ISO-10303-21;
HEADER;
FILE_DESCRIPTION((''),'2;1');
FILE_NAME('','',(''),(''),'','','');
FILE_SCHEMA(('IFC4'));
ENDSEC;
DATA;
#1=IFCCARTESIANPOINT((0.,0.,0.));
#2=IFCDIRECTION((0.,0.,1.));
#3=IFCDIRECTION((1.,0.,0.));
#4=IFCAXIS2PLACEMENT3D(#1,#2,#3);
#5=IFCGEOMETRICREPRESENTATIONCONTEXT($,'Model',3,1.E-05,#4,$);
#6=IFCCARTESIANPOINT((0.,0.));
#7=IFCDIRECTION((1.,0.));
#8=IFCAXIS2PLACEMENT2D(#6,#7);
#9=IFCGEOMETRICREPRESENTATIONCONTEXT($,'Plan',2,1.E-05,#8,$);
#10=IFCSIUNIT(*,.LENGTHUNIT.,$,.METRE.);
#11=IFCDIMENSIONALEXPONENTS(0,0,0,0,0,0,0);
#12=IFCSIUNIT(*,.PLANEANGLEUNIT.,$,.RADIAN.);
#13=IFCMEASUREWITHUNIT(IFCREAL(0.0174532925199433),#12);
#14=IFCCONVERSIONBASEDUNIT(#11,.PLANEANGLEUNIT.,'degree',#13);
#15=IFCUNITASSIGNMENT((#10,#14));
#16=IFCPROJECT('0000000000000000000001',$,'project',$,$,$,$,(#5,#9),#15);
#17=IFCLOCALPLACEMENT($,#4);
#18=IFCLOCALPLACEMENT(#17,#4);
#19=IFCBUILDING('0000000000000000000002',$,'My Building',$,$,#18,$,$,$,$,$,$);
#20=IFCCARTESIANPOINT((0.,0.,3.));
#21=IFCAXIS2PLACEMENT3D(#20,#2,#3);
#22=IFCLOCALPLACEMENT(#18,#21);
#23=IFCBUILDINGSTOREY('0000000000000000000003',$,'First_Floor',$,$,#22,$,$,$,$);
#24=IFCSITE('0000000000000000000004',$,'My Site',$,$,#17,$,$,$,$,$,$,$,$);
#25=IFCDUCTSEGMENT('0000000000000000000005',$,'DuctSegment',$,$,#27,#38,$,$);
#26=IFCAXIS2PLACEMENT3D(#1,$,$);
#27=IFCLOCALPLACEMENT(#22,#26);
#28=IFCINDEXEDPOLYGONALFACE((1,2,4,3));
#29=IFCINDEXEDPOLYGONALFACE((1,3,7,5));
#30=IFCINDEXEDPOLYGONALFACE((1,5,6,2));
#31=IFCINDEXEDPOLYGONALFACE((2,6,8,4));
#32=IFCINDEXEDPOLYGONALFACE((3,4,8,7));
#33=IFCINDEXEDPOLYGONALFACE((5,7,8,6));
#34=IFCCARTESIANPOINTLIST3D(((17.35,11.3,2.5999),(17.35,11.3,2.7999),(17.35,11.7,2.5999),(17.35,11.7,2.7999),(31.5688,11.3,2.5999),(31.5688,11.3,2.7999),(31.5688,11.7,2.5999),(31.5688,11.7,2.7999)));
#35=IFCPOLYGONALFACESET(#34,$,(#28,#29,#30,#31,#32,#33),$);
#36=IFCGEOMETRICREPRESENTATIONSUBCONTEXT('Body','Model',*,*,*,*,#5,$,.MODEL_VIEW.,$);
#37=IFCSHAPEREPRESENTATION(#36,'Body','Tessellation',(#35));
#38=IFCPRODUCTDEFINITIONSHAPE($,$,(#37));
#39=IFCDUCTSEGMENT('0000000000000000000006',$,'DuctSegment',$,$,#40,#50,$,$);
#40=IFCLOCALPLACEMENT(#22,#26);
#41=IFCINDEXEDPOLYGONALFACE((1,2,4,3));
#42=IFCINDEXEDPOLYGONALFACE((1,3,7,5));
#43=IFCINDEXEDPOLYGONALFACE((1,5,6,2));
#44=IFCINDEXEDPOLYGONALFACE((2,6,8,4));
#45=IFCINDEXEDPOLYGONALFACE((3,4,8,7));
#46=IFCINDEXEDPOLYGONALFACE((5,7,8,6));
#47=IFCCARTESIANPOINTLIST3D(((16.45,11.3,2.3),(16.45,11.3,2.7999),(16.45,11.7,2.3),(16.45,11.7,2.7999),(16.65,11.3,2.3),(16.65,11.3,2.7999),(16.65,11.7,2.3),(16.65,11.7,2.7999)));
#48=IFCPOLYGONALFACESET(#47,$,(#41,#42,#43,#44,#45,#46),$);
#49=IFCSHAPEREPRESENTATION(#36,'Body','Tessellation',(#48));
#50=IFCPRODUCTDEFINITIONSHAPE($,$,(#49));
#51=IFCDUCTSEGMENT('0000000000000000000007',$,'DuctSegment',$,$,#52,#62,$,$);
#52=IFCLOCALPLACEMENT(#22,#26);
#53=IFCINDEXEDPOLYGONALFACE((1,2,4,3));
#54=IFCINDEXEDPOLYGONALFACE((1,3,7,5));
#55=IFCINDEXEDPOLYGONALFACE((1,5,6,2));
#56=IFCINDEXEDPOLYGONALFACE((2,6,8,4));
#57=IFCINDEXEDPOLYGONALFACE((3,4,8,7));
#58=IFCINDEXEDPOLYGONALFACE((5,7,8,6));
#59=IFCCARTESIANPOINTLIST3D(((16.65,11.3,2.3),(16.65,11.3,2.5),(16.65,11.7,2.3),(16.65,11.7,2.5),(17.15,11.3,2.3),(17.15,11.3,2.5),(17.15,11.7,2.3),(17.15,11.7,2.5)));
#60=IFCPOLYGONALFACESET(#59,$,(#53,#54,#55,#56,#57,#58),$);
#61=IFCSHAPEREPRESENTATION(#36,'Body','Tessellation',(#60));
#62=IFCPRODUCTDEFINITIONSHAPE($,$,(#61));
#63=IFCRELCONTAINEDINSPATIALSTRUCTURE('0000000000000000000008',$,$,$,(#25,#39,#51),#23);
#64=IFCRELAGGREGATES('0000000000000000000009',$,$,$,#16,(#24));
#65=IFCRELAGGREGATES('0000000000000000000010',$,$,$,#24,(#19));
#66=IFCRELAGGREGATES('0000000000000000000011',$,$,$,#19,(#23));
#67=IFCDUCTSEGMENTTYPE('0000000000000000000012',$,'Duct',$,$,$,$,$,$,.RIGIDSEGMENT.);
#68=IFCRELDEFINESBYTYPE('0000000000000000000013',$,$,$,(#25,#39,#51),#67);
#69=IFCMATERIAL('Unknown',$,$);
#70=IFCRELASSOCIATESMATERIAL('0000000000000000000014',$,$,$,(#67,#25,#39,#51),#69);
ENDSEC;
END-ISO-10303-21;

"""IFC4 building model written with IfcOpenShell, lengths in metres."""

from ifc_helpers import new_model, entity, si_unit, converted_unit, frame, origin_with_axes, origin_2d_with_axis, place, context, subcontext, project, spatial, rectangle, extrude, material, material_profile, profile_set, profile_usage, type_object, element, save


model = new_model("IFC4")

# Units and contexts
model_context = context("Model", 3, precision=1e-05, world=origin_with_axes())
plan_context = context("Plan", 2, precision=1e-05, world=origin_2d_with_axis())
body_context = subcontext(model_context, "Body", "Model", "MODEL_VIEW")
ifc_project = project(units=[si_unit("LENGTHUNIT", "METRE"), converted_unit("PLANEANGLEUNIT", "degree", entity("IfcReal", 0.0174532925199433), si_unit("PLANEANGLEUNIT", "RADIAN"), dimensions=[0, 0, 0, 0, 0, 0, 0])], contexts=[model_context, plan_context])

# Site, building, storey
site_placement = place(None, origin_with_axes())
site = spatial("IfcSite", under=ifc_project, at=site_placement, Name="My Site")
building_placement = place(site_placement, origin_with_axes())
building = spatial("IfcBuilding", under=site, at=building_placement, Name="My Building")
storey_placement = place(building_placement, frame((0.0, 0.0, 3.0), z_axis=(0.0, 0.0, 1.0), x_axis=(1.0, 0.0, 0.0)))
storey = spatial("IfcBuildingStorey", under=building, at=storey_placement, Name="First_Floor")

# Shared definitions
ifc_material = material(Name="Unknown")

# Duct segments
ifc_material_profile_1 = material_profile(ifc_material, rectangle(XDim=0.4, YDim=0.2))
ifc_profile_set_1 = profile_set([ifc_material_profile_1])
duct_segment_type = type_object("IfcDuctSegmentType", Name="Duct", PredefinedType="RIGIDSEGMENT", material=ifc_profile_set_1)
ifc_profile_usage_1 = profile_usage(ifc_profile_set_1, cardinal=5)
duct_segment_1_placement = place(storey_placement, frame((17.35, 11.5, 2.6999), z_axis=(1.0, 0.0, 0.0), x_axis=(0.0, 1.0, 0.0)))
element("IfcDuctSegment", 1, at=duct_segment_1_placement, inside=storey, type_object=duct_segment_type, material=ifc_profile_usage_1, Name="DuctSegment", context=body_context, shape_type="SweptSolid", body=[
    extrude(rectangle(XDim=0.4, YDim=0.2), origin_with_axes(), (0.0, 0.0, 1.0), 14.2188),
])
ifc_profile_usage_2 = profile_usage(ifc_profile_set_1, cardinal=5)
duct_segment_2_placement = place(storey_placement, frame((16.55, 11.5, 2.7999), z_axis=(0.0, 0.0, -1.0), x_axis=(0.0, 1.0, 0.0)))
element("IfcDuctSegment", 2, at=duct_segment_2_placement, inside=storey, type_object=duct_segment_type, material=ifc_profile_usage_2, Name="DuctSegment", context=body_context, shape_type="SweptSolid", body=[
    extrude(rectangle(XDim=0.4, YDim=0.2), origin_with_axes(), (0.0, 0.0, 1.0), 0.5),
])
ifc_profile_usage_3 = profile_usage(ifc_profile_set_1, cardinal=5)
duct_segment_3_placement = place(storey_placement, frame((17.15, 11.5, 2.4), z_axis=(-1.0, 0.0, 0.0), x_axis=(0.0, 1.0, 0.0)))
element("IfcDuctSegment", 3, at=duct_segment_3_placement, inside=storey, type_object=duct_segment_type, material=ifc_profile_usage_3, Name="DuctSegment", context=body_context, shape_type="SweptSolid", body=[
    extrude(rectangle(XDim=0.4, YDim=0.2), origin_with_axes(), (0.0, 0.0, 1.0), 0.5),
])

save(model, "model.ifc")
